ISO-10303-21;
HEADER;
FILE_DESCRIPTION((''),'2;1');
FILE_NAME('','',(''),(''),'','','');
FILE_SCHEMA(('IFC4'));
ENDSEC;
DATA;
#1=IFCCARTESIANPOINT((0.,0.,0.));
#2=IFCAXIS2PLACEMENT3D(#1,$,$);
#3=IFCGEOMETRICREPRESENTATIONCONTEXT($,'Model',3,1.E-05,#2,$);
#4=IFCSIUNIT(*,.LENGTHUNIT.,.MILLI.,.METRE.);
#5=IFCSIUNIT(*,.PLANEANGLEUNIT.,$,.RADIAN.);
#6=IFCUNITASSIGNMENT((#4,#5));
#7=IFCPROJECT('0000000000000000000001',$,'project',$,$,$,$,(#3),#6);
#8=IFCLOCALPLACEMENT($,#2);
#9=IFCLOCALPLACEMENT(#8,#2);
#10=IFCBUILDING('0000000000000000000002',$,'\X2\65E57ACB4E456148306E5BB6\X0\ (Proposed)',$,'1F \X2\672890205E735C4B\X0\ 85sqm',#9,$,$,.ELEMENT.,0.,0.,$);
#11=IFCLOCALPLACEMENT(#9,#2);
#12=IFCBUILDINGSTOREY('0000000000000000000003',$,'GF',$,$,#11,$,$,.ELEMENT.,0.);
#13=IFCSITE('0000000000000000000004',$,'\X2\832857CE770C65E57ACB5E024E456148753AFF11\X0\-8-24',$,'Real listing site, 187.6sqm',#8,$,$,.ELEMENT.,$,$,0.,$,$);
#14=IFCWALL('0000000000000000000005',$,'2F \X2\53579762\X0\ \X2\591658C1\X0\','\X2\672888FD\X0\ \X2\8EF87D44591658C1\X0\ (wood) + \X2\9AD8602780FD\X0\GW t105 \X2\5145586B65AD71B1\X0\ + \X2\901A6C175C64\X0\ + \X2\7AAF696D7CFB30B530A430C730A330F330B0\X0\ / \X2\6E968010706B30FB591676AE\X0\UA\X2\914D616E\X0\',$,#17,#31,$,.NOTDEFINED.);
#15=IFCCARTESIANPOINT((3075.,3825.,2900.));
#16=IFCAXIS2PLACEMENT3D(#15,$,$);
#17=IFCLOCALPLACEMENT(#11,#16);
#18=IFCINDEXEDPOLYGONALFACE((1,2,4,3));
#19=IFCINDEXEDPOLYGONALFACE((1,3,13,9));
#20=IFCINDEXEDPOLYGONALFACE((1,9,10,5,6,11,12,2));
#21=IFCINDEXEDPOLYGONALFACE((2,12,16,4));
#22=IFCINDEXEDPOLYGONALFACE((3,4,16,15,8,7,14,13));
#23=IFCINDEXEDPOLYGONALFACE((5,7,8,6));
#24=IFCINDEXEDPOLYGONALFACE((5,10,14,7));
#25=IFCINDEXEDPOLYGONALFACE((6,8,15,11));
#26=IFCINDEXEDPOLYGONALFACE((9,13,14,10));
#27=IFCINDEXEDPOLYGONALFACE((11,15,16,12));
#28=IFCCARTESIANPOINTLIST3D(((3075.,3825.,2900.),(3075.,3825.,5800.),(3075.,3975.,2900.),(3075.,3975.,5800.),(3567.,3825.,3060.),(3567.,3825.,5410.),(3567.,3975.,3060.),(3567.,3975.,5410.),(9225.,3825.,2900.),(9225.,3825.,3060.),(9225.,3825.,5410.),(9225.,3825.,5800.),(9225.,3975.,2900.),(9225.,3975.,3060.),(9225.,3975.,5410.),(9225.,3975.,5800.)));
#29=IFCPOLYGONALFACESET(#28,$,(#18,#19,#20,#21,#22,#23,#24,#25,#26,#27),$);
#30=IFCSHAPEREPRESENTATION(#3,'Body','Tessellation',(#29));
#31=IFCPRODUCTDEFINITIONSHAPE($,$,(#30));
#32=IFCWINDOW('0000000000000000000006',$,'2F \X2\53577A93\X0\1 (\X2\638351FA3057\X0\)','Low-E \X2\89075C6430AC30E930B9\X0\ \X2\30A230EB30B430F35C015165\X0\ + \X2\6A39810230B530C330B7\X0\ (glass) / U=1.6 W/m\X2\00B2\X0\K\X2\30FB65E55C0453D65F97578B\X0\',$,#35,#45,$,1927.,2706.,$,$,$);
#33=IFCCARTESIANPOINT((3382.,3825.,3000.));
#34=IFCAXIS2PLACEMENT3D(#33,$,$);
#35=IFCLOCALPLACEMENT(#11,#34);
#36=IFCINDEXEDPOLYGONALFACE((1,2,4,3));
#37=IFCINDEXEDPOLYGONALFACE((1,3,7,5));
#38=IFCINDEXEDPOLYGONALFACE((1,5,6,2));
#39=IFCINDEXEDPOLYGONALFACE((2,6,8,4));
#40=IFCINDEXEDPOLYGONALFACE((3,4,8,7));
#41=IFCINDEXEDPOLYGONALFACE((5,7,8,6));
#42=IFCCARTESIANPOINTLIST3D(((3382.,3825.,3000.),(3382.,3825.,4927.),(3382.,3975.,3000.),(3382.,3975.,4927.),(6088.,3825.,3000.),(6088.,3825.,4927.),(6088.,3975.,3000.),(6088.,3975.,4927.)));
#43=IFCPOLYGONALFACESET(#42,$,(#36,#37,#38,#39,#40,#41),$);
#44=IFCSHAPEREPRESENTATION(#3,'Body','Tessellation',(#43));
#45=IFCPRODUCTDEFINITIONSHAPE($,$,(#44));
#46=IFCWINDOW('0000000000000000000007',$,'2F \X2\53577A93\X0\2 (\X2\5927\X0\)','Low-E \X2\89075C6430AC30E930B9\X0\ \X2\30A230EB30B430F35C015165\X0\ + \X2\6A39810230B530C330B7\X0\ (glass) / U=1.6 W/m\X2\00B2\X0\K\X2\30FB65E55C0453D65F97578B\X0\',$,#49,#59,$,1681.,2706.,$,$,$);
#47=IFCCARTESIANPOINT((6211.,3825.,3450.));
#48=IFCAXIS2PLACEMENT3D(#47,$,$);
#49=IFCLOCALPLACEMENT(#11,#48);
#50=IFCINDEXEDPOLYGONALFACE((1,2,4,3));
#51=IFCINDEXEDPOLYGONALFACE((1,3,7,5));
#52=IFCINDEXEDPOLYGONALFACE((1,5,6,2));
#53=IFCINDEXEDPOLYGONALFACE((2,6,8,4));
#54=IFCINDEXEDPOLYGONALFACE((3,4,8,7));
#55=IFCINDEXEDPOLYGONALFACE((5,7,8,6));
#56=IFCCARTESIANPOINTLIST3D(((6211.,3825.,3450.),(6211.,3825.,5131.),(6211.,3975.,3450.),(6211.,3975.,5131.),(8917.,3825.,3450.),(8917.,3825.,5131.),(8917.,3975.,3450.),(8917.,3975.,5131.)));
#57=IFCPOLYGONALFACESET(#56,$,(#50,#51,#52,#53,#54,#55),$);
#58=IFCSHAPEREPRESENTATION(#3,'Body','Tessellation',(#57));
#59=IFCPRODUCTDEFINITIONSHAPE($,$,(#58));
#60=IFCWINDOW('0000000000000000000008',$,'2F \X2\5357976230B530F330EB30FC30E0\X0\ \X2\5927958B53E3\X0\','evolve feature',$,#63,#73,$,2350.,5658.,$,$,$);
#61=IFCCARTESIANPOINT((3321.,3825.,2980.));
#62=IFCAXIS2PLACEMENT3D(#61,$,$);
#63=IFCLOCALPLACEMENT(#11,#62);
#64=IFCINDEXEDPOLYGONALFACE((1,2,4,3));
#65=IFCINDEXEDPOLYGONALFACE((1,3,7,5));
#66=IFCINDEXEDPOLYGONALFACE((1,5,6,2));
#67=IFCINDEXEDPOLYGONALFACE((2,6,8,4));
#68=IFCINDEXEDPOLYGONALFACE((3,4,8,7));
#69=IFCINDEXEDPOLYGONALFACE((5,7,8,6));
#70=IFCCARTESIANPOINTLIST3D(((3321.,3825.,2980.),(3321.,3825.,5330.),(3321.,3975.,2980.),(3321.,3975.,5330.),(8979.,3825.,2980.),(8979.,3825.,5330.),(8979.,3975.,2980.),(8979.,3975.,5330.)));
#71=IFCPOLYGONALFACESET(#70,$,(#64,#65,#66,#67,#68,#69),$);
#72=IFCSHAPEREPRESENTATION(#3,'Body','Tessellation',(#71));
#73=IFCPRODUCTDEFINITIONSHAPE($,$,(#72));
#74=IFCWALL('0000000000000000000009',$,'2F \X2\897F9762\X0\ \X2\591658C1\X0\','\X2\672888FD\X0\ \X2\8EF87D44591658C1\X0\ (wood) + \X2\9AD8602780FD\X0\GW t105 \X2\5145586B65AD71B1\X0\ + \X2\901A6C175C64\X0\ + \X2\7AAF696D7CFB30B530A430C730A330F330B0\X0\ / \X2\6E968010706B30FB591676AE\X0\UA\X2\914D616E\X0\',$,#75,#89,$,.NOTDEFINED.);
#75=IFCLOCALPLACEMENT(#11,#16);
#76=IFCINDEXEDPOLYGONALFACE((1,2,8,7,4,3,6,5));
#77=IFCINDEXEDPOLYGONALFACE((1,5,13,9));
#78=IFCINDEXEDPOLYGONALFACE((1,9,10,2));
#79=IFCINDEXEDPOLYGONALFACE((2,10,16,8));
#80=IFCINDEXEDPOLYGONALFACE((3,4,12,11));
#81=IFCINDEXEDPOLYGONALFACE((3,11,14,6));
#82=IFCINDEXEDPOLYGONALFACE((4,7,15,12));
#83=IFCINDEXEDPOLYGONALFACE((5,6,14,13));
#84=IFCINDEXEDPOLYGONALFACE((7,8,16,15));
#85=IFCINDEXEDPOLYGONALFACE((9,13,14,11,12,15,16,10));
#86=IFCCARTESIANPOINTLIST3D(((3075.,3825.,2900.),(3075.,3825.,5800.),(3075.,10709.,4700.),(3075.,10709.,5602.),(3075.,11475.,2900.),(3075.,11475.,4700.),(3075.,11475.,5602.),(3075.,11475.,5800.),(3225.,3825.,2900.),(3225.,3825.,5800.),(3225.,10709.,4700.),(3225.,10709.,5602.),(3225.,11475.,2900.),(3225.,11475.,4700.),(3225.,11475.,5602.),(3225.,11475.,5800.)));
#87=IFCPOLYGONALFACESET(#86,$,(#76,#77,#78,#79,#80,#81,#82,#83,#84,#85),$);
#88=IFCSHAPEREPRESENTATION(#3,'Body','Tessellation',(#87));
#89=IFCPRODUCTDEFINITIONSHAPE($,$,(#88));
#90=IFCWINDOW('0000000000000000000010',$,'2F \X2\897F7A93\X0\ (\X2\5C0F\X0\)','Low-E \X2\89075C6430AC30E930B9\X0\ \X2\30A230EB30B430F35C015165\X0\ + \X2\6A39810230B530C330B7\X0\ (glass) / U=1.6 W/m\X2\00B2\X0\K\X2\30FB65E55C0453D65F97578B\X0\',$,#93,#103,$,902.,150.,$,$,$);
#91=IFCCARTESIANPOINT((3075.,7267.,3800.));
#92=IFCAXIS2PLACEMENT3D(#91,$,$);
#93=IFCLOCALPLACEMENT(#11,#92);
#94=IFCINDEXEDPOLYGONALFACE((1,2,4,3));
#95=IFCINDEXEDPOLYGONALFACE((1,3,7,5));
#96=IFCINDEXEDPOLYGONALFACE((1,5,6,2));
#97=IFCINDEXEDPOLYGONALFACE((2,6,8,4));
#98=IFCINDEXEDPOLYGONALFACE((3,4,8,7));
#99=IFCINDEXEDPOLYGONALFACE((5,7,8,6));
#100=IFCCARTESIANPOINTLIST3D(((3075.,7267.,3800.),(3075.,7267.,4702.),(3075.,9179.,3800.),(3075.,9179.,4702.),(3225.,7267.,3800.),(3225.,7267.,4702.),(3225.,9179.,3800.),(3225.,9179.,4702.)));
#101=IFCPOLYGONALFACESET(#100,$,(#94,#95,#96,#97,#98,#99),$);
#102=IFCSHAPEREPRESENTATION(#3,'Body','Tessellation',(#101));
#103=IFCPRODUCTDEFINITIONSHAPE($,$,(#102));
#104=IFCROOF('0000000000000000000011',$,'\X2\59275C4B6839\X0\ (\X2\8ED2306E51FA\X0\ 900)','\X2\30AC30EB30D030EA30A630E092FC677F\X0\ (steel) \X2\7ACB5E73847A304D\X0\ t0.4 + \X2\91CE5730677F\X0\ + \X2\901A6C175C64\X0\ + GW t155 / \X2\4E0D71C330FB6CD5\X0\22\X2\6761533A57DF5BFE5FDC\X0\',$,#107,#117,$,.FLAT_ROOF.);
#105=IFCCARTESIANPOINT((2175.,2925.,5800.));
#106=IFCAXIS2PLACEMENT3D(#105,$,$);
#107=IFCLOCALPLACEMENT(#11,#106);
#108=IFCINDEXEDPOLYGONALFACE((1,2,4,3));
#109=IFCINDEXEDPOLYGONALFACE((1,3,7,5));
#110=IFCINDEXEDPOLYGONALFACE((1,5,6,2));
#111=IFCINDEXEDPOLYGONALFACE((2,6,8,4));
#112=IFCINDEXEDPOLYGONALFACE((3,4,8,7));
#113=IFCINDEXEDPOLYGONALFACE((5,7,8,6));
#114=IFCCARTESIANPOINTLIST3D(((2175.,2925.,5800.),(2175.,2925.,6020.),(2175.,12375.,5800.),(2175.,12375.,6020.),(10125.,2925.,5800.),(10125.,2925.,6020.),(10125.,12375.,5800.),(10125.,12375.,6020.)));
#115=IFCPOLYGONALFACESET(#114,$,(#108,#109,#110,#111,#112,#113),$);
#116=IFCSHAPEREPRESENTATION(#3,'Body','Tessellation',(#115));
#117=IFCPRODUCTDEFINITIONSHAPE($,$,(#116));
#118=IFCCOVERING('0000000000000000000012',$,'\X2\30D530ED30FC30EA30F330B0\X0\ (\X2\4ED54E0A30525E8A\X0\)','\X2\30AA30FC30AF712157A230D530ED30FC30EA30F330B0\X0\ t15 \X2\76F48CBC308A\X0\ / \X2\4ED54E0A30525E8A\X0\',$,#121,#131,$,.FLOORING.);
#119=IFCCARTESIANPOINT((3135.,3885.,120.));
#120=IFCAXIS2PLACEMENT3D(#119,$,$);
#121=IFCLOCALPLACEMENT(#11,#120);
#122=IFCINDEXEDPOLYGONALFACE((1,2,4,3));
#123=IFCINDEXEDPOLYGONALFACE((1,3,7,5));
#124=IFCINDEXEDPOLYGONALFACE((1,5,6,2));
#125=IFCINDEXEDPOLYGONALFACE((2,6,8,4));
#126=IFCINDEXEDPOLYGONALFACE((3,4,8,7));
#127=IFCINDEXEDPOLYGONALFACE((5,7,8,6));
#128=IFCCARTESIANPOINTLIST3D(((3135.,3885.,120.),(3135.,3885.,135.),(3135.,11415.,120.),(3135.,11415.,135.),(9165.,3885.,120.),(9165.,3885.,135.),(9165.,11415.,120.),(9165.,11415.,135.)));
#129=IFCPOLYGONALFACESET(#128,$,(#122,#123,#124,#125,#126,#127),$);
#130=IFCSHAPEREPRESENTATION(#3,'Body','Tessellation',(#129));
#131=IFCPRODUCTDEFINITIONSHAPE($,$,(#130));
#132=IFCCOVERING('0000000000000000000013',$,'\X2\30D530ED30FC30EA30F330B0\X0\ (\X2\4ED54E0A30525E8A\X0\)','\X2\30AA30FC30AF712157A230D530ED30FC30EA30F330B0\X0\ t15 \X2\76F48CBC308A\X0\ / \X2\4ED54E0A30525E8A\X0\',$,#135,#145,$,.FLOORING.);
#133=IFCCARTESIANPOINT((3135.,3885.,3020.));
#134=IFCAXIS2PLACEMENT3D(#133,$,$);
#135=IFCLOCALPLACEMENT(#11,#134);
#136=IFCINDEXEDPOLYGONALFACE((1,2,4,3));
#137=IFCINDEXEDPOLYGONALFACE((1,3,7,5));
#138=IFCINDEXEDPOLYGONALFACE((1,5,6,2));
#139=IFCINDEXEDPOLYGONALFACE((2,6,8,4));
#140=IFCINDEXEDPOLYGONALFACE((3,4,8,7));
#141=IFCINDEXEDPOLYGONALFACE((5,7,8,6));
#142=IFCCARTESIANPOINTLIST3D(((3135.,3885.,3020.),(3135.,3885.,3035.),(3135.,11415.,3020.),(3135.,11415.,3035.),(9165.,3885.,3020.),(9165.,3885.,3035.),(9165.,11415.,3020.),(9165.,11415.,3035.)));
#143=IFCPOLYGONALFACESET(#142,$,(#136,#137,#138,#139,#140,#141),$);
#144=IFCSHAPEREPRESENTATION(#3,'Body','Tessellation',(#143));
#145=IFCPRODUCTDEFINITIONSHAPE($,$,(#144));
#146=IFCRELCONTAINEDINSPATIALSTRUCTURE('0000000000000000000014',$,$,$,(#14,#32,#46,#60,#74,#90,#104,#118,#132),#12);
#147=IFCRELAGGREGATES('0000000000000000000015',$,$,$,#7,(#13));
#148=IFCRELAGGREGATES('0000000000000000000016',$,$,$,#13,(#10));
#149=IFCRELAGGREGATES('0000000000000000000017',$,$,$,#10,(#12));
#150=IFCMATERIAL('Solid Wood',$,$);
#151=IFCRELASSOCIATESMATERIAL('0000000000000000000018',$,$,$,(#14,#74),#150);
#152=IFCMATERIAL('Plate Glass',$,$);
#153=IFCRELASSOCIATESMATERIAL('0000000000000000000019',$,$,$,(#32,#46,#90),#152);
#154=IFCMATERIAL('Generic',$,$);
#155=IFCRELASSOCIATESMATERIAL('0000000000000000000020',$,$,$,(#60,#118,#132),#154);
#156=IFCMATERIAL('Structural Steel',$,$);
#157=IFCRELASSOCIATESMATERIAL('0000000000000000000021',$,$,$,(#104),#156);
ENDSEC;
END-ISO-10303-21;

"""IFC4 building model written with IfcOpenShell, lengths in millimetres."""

from ifc_helpers import new_model, si_unit, frame, frame_2d, origin, place, context, project, spatial, rectangle, extrude, material, element, fill, save


model = new_model("IFC4")

# Units and contexts
model_context = context("Model", 3, precision=1e-05, world=origin())
ifc_project = project(units=[si_unit("LENGTHUNIT", "METRE", prefix="MILLI"), si_unit("PLANEANGLEUNIT", "RADIAN")], contexts=[model_context])

# Site, building, storey
site_placement = place(None, origin())
site = spatial("IfcSite", under=ifc_project, at=site_placement, Name="茨城県日立市久慈町１-8-24", ObjectType="Real listing site, 187.6sqm", CompositionType="ELEMENT", RefElevation=0.0)
building_placement = place(site_placement, origin())
building = spatial("IfcBuilding", under=site, at=building_placement, Name="日立久慈の家 (Proposed)", ObjectType="1F 木造平屋 85sqm", CompositionType="ELEMENT", ElevationOfRefHeight=0.0, ElevationOfTerrain=0.0)
storey_placement = place(building_placement, origin())
storey = spatial("IfcBuildingStorey", under=building, at=storey_placement, Name="GF", CompositionType="ELEMENT", Elevation=0.0)

# Shared definitions
ifc_material_1 = material(Name="Solid Wood")
ifc_material_2 = material(Name="Generic")

# Shared definitions
ifc_material_3 = material(Name="Plate Glass")

# Wall, openings, windows
wall_1_placement = place(storey_placement, frame((3075.0, 3825.0, 2900.0)))
wall_1 = element("IfcWall", 1, at=wall_1_placement, inside=storey, material=ifc_material_1, Name="2F 南面 外壁", Description="木製 軸組外壁 (wood) + 高性能GW t105 充填断熱 + 通気層 + 窯業系サイディング / 準耐火・外皮UA配慮", PredefinedType="NOTDEFINED", context=model_context, shape_type="SweptSolid", body=[
    extrude(rectangle(XDim=6150.0, YDim=150.0, at=frame_2d((3075.0, 75.0))), frame((3075.0, 3825.0, 2900.0)), (0.0, 0.0, 1.0), 2900.0),
])
opening_1_placement = place(storey_placement, frame((3382.0, 3825.0, 3000.0)))
opening_1 = element("IfcOpeningElement", 2, at=opening_1_placement, cuts=wall_1, PredefinedType="NOTDEFINED", context=model_context, shape_type="SweptSolid", body=[
    extrude(rectangle(XDim=2706.0, YDim=150.0, at=frame_2d((1353.0, 75.0))), frame((3382.0, 3825.0, 3000.0)), (0.0, 0.0, 1.0), 1927.0),
])
opening_2_placement = place(storey_placement, frame((6211.0, 3825.0, 3450.0)))
opening_2 = element("IfcOpeningElement", 3, at=opening_2_placement, cuts=wall_1, PredefinedType="NOTDEFINED", context=model_context, shape_type="SweptSolid", body=[
    extrude(rectangle(XDim=2706.0, YDim=150.0, at=frame_2d((1353.0, 75.0))), frame((6211.0, 3825.0, 3450.0)), (0.0, 0.0, 1.0), 1681.0),
])
opening_3_placement = place(storey_placement, frame((3321.0, 3825.0, 2980.0)))
opening_3 = element("IfcOpeningElement", 4, at=opening_3_placement, cuts=wall_1, PredefinedType="NOTDEFINED", context=model_context, shape_type="SweptSolid", body=[
    extrude(rectangle(XDim=5658.0, YDim=150.0, at=frame_2d((2829.0, 75.0))), frame((3321.0, 3825.0, 2980.0)), (0.0, 0.0, 1.0), 2350.0),
])
window_1_placement = place(storey_placement, frame((3382.0, 3825.0, 3000.0)))
window_1 = element("IfcWindow", 5, at=window_1_placement, inside=storey, material=ifc_material_3, Name="2F 南窓1 (掃出し)", Description="Low-E 複層ガラス アルゴン封入 + 樹脂サッシ (glass) / U=1.6 W/m²K・日射取得型", OverallHeight=1927.0, OverallWidth=2706.0, context=model_context, shape_type="SweptSolid", body=[
    extrude(rectangle(XDim=2706.0, YDim=150.0, at=frame_2d((1353.0, 75.0))), frame((3382.0, 3825.0, 3000.0)), (0.0, 0.0, 1.0), 1927.0),
])
fill(opening_1, window_1)
window_2_placement = place(storey_placement, frame((6211.0, 3825.0, 3450.0)))
window_2 = element("IfcWindow", 6, at=window_2_placement, inside=storey, material=ifc_material_3, Name="2F 南窓2 (大)", Description="Low-E 複層ガラス アルゴン封入 + 樹脂サッシ (glass) / U=1.6 W/m²K・日射取得型", OverallHeight=1681.0, OverallWidth=2706.0, context=model_context, shape_type="SweptSolid", body=[
    extrude(rectangle(XDim=2706.0, YDim=150.0, at=frame_2d((1353.0, 75.0))), frame((6211.0, 3825.0, 3450.0)), (0.0, 0.0, 1.0), 1681.0),
])
fill(opening_2, window_2)
window_3_placement = place(storey_placement, frame((3321.0, 3825.0, 2980.0)))
window_3 = element("IfcWindow", 7, at=window_3_placement, inside=storey, material=ifc_material_2, Name="2F 南面サンルーム 大開口", Description="evolve feature", OverallHeight=2350.0, OverallWidth=5658.0, context=model_context, shape_type="SweptSolid", body=[
    extrude(rectangle(XDim=5658.0, YDim=150.0, at=frame_2d((2829.0, 75.0))), frame((3321.0, 3825.0, 2980.0)), (0.0, 0.0, 1.0), 2350.0),
])
fill(opening_3, window_3)

# Wall, opening, window
wall_2_placement = place(storey_placement, frame((3075.0, 3825.0, 2900.0)))
wall_2 = element("IfcWall", 8, at=wall_2_placement, inside=storey, material=ifc_material_1, Name="2F 西面 外壁", Description="木製 軸組外壁 (wood) + 高性能GW t105 充填断熱 + 通気層 + 窯業系サイディング / 準耐火・外皮UA配慮", PredefinedType="NOTDEFINED", context=model_context, shape_type="SweptSolid", body=[
    extrude(rectangle(XDim=150.0, YDim=7650.0, at=frame_2d((75.0, 3825.0))), frame((3075.0, 3825.0, 2900.0)), (0.0, 0.0, 1.0), 2900.0),
])
opening_4_placement = place(storey_placement, frame((3075.0, 7267.0, 3800.0)))
opening_4 = element("IfcOpeningElement", 9, at=opening_4_placement, cuts=wall_2, PredefinedType="NOTDEFINED", context=model_context, shape_type="SweptSolid", body=[
    extrude(rectangle(XDim=150.0, YDim=1912.0, at=frame_2d((75.0, 956.0))), frame((3075.0, 7267.0, 3800.0)), (0.0, 0.0, 1.0), 902.0),
])
window_4_placement = place(storey_placement, frame((3075.0, 7267.0, 3800.0)))
window_4 = element("IfcWindow", 10, at=window_4_placement, inside=storey, material=ifc_material_3, Name="2F 西窓 (小)", Description="Low-E 複層ガラス アルゴン封入 + 樹脂サッシ (glass) / U=1.6 W/m²K・日射取得型", OverallHeight=902.0, OverallWidth=150.0, context=model_context, shape_type="SweptSolid", body=[
    extrude(rectangle(XDim=150.0, YDim=1912.0, at=frame_2d((75.0, 956.0))), frame((3075.0, 7267.0, 3800.0)), (0.0, 0.0, 1.0), 902.0),
])
fill(opening_4, window_4)

# Roof
ifc_material_4 = material(Name="Structural Steel")
roof_placement = place(storey_placement, frame((2175.0, 2925.0, 5800.0)))
element("IfcRoof", 11, at=roof_placement, inside=storey, material=ifc_material_4, Name="大屋根 (軒の出 900)", Description="ガルバリウム鋼板 (steel) 立平葺き t0.4 + 野地板 + 通気層 + GW t155 / 不燃・法22条区域対応", PredefinedType="FLAT_ROOF", context=model_context, shape_type="SweptSolid", body=[
    extrude(rectangle(XDim=7950.0, YDim=9450.0, at=frame_2d((3975.0, 4725.0))), frame((2175.0, 2925.0, 5800.0)), (0.0, 0.0, 1.0), 220.0),
])

# Coverings
covering_1_placement = place(storey_placement, frame((3135.0, 3885.0, 120.0)))
element("IfcCovering", 12, at=covering_1_placement, inside=storey, material=ifc_material_2, Name="フローリング (仕上げ床)", Description="オーク無垢フローリング t15 直貼り / 仕上げ床", PredefinedType="FLOORING", context=model_context, shape_type="SweptSolid", body=[
    extrude(rectangle(XDim=6030.0, YDim=7530.0, at=frame_2d((3015.0, 3765.0))), frame((3135.0, 3885.0, 120.0)), (0.0, 0.0, 1.0), 15.0),
])
covering_2_placement = place(storey_placement, frame((3135.0, 3885.0, 3020.0)))
element("IfcCovering", 13, at=covering_2_placement, inside=storey, material=ifc_material_2, Name="フローリング (仕上げ床)", Description="オーク無垢フローリング t15 直貼り / 仕上げ床", PredefinedType="FLOORING", context=model_context, shape_type="SweptSolid", body=[
    extrude(rectangle(XDim=6030.0, YDim=7530.0, at=frame_2d((3015.0, 3765.0))), frame((3135.0, 3885.0, 3020.0)), (0.0, 0.0, 1.0), 15.0),
])

save(model, "model.ifc")
